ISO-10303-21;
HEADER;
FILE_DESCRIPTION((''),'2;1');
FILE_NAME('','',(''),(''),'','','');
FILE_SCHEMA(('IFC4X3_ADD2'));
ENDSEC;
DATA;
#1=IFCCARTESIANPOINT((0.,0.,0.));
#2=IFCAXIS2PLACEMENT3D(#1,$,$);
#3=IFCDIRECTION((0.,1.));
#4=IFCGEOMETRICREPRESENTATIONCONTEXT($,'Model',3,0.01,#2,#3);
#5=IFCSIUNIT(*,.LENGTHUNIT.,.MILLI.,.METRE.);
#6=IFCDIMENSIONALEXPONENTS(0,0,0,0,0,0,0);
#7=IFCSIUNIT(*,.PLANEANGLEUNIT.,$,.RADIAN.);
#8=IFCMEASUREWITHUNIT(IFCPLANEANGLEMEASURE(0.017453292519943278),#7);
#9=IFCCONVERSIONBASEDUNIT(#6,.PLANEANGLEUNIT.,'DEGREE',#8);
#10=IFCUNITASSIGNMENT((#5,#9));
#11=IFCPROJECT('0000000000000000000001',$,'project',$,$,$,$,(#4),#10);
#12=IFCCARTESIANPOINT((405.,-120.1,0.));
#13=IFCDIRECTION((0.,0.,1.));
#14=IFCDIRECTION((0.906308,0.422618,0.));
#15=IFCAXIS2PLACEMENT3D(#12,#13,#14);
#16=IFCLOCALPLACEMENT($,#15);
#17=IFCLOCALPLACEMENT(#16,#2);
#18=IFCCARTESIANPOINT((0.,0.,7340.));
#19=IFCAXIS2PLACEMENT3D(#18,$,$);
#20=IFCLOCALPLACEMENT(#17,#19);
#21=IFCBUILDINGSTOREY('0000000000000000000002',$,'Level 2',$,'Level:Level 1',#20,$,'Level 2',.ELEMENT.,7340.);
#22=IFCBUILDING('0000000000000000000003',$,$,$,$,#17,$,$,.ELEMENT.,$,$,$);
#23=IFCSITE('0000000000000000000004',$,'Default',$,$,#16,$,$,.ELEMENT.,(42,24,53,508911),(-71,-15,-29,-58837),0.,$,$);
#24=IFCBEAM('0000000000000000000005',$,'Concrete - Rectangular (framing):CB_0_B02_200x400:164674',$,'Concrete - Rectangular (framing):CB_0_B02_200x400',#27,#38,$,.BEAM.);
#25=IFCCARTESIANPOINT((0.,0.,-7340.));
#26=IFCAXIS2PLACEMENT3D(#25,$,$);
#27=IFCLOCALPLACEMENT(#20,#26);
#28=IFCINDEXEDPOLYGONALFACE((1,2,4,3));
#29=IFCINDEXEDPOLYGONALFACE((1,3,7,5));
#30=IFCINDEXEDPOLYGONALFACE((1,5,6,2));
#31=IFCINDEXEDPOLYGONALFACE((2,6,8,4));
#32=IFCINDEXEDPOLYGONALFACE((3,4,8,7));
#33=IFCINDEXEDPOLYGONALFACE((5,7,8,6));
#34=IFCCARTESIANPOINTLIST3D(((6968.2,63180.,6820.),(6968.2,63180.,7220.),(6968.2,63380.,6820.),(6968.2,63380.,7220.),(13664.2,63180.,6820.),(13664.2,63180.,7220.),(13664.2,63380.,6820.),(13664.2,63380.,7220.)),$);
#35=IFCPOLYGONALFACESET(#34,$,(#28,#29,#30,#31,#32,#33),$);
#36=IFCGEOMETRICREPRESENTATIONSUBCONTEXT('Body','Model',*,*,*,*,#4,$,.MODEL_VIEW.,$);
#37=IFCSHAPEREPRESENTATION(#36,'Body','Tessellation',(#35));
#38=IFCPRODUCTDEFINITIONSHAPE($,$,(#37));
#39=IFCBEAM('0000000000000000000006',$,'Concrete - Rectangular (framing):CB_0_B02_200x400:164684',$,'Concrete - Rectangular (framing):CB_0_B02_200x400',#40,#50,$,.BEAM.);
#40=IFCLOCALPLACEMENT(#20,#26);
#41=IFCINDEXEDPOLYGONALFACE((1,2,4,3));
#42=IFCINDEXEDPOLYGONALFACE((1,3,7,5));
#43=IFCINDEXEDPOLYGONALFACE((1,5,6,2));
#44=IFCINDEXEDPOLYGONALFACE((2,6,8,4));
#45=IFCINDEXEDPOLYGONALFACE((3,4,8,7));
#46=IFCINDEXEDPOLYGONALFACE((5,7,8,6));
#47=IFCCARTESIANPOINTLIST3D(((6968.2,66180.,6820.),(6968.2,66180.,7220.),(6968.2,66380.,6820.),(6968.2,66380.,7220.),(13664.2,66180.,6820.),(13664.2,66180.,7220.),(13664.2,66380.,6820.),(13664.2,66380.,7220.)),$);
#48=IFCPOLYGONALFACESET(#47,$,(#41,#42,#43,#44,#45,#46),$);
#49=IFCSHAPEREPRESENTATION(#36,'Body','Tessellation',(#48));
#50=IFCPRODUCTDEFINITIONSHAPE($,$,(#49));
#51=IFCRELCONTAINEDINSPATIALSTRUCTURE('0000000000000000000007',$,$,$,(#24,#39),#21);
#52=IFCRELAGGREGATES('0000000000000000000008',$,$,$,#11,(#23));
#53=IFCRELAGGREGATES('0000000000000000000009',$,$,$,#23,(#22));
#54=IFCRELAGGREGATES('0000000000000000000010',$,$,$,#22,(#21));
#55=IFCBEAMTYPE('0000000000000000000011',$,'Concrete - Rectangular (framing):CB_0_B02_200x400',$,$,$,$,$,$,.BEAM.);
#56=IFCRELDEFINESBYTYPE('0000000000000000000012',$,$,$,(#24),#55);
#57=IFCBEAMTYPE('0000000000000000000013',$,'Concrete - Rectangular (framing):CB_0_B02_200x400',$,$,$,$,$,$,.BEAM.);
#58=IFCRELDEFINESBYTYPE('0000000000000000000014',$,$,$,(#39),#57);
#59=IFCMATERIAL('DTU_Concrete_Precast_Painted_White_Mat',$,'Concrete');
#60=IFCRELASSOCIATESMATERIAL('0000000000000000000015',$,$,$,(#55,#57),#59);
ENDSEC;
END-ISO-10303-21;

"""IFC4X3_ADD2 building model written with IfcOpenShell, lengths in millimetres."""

from ifc_helpers import new_model, entity, si_unit, converted_unit, direction, frame, frame_2d, origin, origin_2d_with_axis, place, context, subcontext, project, spatial, rectangle, extrude, source, transform, mapped, material, material_profile, profile_set, type_object, type_shapes, element, save


model = new_model("IFC4X3_ADD2")

# Units and contexts
model_context = context("Model", 3, precision=0.01, world=origin(), true_north=direction((0.0, 1.0)))
body_context = subcontext(model_context, "Body", "Model", "MODEL_VIEW")
ifc_project = project(units=[si_unit("LENGTHUNIT", "METRE", prefix="MILLI"), converted_unit("PLANEANGLEUNIT", "DEGREE", entity("IfcPlaneAngleMeasure", 0.017453292519943278), si_unit("PLANEANGLEUNIT", "RADIAN"), dimensions=[0, 0, 0, 0, 0, 0, 0])], contexts=[model_context])

# Site, building, storey
site_placement = place(None, frame((405.0, -120.1, 0.0), z_axis=(0.0, 0.0, 1.0), x_axis=(0.906308, 0.422618, 0.0)))
site = spatial("IfcSite", under=ifc_project, at=site_placement, Name="Default", CompositionType="ELEMENT", RefLatitude=(42, 24, 53, 508911), RefLongitude=(-71, -15, -29, -58837), RefElevation=0.0)
building_placement = place(site_placement, origin())
building = spatial("IfcBuilding", under=site, at=building_placement, CompositionType="ELEMENT")
storey_placement = place(building_placement, frame((0.0, 0.0, 7340.0)))
storey = spatial("IfcBuildingStorey", under=building, at=storey_placement, Name="Level 2", ObjectType="Level:Level 1", LongName="Level 2", CompositionType="ELEMENT", Elevation=7340.0)

# Beams
ifc_material_1 = material(Name="DTU_Concrete_Precast_Painted_White_Mat", Category="Concrete")
ifc_material_profile_1 = material_profile(ifc_material_1, rectangle(XDim=7035.5, YDim=200.0, at=frame_2d((0.0, 0.0), x_axis=(1.0, 0.0))), Name="CB_0_B02_200x400")
ifc_profile_set_1 = profile_set([ifc_material_profile_1], Name="CB_0_B02_200x400")
beam_type_1 = type_object("IfcBeamType", Name="Concrete - Rectangular (framing):CB_0_B02_200x400", PredefinedType="BEAM", material=ifc_profile_set_1)
shared_shape_1 = source(origin(), body_context, "Body", "SweptSolid", [
    extrude(rectangle(XDim=400.0, YDim=200.0, at=origin_2d_with_axis()), frame((6968.2, 63280.0, 7020.0), z_axis=(1.0, 0.0, 0.0), x_axis=(0.0, 0.0, -1.0)), (0.0, 0.0, 1.0), 6696.0),
])
type_shapes(beam_type_1, [shared_shape_1])
beam_1_placement = place(storey_placement, frame((0.0, 0.0, -7340.0)))
element("IfcBeam", 1, at=beam_1_placement, inside=storey, type_object=beam_type_1, Name="Concrete - Rectangular (framing):CB_0_B02_200x400:164674", ObjectType="Concrete - Rectangular (framing):CB_0_B02_200x400", PredefinedType="BEAM", context=body_context, shape_type="MappedRepresentation", body=[
    mapped(shared_shape_1, transform((0.0, 0.0, 0.0), scale=1.0)),
])
beam_type_2 = type_object("IfcBeamType", Name="Concrete - Rectangular (framing):CB_0_B02_200x400", PredefinedType="BEAM", material=ifc_profile_set_1)
shared_shape_2 = source(origin(), body_context, "Body", "SweptSolid", [
    extrude(rectangle(XDim=400.0, YDim=200.0, at=origin_2d_with_axis()), frame((6968.2, 66280.0, 7020.0), z_axis=(1.0, 0.0, 0.0), x_axis=(0.0, 0.0, -1.0)), (0.0, 0.0, 1.0), 6696.0),
])
type_shapes(beam_type_2, [shared_shape_2])
beam_2_placement = place(storey_placement, frame((0.0, 0.0, -7340.0)))
element("IfcBeam", 2, at=beam_2_placement, inside=storey, type_object=beam_type_2, Name="Concrete - Rectangular (framing):CB_0_B02_200x400:164684", ObjectType="Concrete - Rectangular (framing):CB_0_B02_200x400", PredefinedType="BEAM", context=body_context, shape_type="MappedRepresentation", body=[
    mapped(shared_shape_2, transform((0.0, 0.0, 0.0), scale=1.0)),
])

save(model, "model.ifc")
